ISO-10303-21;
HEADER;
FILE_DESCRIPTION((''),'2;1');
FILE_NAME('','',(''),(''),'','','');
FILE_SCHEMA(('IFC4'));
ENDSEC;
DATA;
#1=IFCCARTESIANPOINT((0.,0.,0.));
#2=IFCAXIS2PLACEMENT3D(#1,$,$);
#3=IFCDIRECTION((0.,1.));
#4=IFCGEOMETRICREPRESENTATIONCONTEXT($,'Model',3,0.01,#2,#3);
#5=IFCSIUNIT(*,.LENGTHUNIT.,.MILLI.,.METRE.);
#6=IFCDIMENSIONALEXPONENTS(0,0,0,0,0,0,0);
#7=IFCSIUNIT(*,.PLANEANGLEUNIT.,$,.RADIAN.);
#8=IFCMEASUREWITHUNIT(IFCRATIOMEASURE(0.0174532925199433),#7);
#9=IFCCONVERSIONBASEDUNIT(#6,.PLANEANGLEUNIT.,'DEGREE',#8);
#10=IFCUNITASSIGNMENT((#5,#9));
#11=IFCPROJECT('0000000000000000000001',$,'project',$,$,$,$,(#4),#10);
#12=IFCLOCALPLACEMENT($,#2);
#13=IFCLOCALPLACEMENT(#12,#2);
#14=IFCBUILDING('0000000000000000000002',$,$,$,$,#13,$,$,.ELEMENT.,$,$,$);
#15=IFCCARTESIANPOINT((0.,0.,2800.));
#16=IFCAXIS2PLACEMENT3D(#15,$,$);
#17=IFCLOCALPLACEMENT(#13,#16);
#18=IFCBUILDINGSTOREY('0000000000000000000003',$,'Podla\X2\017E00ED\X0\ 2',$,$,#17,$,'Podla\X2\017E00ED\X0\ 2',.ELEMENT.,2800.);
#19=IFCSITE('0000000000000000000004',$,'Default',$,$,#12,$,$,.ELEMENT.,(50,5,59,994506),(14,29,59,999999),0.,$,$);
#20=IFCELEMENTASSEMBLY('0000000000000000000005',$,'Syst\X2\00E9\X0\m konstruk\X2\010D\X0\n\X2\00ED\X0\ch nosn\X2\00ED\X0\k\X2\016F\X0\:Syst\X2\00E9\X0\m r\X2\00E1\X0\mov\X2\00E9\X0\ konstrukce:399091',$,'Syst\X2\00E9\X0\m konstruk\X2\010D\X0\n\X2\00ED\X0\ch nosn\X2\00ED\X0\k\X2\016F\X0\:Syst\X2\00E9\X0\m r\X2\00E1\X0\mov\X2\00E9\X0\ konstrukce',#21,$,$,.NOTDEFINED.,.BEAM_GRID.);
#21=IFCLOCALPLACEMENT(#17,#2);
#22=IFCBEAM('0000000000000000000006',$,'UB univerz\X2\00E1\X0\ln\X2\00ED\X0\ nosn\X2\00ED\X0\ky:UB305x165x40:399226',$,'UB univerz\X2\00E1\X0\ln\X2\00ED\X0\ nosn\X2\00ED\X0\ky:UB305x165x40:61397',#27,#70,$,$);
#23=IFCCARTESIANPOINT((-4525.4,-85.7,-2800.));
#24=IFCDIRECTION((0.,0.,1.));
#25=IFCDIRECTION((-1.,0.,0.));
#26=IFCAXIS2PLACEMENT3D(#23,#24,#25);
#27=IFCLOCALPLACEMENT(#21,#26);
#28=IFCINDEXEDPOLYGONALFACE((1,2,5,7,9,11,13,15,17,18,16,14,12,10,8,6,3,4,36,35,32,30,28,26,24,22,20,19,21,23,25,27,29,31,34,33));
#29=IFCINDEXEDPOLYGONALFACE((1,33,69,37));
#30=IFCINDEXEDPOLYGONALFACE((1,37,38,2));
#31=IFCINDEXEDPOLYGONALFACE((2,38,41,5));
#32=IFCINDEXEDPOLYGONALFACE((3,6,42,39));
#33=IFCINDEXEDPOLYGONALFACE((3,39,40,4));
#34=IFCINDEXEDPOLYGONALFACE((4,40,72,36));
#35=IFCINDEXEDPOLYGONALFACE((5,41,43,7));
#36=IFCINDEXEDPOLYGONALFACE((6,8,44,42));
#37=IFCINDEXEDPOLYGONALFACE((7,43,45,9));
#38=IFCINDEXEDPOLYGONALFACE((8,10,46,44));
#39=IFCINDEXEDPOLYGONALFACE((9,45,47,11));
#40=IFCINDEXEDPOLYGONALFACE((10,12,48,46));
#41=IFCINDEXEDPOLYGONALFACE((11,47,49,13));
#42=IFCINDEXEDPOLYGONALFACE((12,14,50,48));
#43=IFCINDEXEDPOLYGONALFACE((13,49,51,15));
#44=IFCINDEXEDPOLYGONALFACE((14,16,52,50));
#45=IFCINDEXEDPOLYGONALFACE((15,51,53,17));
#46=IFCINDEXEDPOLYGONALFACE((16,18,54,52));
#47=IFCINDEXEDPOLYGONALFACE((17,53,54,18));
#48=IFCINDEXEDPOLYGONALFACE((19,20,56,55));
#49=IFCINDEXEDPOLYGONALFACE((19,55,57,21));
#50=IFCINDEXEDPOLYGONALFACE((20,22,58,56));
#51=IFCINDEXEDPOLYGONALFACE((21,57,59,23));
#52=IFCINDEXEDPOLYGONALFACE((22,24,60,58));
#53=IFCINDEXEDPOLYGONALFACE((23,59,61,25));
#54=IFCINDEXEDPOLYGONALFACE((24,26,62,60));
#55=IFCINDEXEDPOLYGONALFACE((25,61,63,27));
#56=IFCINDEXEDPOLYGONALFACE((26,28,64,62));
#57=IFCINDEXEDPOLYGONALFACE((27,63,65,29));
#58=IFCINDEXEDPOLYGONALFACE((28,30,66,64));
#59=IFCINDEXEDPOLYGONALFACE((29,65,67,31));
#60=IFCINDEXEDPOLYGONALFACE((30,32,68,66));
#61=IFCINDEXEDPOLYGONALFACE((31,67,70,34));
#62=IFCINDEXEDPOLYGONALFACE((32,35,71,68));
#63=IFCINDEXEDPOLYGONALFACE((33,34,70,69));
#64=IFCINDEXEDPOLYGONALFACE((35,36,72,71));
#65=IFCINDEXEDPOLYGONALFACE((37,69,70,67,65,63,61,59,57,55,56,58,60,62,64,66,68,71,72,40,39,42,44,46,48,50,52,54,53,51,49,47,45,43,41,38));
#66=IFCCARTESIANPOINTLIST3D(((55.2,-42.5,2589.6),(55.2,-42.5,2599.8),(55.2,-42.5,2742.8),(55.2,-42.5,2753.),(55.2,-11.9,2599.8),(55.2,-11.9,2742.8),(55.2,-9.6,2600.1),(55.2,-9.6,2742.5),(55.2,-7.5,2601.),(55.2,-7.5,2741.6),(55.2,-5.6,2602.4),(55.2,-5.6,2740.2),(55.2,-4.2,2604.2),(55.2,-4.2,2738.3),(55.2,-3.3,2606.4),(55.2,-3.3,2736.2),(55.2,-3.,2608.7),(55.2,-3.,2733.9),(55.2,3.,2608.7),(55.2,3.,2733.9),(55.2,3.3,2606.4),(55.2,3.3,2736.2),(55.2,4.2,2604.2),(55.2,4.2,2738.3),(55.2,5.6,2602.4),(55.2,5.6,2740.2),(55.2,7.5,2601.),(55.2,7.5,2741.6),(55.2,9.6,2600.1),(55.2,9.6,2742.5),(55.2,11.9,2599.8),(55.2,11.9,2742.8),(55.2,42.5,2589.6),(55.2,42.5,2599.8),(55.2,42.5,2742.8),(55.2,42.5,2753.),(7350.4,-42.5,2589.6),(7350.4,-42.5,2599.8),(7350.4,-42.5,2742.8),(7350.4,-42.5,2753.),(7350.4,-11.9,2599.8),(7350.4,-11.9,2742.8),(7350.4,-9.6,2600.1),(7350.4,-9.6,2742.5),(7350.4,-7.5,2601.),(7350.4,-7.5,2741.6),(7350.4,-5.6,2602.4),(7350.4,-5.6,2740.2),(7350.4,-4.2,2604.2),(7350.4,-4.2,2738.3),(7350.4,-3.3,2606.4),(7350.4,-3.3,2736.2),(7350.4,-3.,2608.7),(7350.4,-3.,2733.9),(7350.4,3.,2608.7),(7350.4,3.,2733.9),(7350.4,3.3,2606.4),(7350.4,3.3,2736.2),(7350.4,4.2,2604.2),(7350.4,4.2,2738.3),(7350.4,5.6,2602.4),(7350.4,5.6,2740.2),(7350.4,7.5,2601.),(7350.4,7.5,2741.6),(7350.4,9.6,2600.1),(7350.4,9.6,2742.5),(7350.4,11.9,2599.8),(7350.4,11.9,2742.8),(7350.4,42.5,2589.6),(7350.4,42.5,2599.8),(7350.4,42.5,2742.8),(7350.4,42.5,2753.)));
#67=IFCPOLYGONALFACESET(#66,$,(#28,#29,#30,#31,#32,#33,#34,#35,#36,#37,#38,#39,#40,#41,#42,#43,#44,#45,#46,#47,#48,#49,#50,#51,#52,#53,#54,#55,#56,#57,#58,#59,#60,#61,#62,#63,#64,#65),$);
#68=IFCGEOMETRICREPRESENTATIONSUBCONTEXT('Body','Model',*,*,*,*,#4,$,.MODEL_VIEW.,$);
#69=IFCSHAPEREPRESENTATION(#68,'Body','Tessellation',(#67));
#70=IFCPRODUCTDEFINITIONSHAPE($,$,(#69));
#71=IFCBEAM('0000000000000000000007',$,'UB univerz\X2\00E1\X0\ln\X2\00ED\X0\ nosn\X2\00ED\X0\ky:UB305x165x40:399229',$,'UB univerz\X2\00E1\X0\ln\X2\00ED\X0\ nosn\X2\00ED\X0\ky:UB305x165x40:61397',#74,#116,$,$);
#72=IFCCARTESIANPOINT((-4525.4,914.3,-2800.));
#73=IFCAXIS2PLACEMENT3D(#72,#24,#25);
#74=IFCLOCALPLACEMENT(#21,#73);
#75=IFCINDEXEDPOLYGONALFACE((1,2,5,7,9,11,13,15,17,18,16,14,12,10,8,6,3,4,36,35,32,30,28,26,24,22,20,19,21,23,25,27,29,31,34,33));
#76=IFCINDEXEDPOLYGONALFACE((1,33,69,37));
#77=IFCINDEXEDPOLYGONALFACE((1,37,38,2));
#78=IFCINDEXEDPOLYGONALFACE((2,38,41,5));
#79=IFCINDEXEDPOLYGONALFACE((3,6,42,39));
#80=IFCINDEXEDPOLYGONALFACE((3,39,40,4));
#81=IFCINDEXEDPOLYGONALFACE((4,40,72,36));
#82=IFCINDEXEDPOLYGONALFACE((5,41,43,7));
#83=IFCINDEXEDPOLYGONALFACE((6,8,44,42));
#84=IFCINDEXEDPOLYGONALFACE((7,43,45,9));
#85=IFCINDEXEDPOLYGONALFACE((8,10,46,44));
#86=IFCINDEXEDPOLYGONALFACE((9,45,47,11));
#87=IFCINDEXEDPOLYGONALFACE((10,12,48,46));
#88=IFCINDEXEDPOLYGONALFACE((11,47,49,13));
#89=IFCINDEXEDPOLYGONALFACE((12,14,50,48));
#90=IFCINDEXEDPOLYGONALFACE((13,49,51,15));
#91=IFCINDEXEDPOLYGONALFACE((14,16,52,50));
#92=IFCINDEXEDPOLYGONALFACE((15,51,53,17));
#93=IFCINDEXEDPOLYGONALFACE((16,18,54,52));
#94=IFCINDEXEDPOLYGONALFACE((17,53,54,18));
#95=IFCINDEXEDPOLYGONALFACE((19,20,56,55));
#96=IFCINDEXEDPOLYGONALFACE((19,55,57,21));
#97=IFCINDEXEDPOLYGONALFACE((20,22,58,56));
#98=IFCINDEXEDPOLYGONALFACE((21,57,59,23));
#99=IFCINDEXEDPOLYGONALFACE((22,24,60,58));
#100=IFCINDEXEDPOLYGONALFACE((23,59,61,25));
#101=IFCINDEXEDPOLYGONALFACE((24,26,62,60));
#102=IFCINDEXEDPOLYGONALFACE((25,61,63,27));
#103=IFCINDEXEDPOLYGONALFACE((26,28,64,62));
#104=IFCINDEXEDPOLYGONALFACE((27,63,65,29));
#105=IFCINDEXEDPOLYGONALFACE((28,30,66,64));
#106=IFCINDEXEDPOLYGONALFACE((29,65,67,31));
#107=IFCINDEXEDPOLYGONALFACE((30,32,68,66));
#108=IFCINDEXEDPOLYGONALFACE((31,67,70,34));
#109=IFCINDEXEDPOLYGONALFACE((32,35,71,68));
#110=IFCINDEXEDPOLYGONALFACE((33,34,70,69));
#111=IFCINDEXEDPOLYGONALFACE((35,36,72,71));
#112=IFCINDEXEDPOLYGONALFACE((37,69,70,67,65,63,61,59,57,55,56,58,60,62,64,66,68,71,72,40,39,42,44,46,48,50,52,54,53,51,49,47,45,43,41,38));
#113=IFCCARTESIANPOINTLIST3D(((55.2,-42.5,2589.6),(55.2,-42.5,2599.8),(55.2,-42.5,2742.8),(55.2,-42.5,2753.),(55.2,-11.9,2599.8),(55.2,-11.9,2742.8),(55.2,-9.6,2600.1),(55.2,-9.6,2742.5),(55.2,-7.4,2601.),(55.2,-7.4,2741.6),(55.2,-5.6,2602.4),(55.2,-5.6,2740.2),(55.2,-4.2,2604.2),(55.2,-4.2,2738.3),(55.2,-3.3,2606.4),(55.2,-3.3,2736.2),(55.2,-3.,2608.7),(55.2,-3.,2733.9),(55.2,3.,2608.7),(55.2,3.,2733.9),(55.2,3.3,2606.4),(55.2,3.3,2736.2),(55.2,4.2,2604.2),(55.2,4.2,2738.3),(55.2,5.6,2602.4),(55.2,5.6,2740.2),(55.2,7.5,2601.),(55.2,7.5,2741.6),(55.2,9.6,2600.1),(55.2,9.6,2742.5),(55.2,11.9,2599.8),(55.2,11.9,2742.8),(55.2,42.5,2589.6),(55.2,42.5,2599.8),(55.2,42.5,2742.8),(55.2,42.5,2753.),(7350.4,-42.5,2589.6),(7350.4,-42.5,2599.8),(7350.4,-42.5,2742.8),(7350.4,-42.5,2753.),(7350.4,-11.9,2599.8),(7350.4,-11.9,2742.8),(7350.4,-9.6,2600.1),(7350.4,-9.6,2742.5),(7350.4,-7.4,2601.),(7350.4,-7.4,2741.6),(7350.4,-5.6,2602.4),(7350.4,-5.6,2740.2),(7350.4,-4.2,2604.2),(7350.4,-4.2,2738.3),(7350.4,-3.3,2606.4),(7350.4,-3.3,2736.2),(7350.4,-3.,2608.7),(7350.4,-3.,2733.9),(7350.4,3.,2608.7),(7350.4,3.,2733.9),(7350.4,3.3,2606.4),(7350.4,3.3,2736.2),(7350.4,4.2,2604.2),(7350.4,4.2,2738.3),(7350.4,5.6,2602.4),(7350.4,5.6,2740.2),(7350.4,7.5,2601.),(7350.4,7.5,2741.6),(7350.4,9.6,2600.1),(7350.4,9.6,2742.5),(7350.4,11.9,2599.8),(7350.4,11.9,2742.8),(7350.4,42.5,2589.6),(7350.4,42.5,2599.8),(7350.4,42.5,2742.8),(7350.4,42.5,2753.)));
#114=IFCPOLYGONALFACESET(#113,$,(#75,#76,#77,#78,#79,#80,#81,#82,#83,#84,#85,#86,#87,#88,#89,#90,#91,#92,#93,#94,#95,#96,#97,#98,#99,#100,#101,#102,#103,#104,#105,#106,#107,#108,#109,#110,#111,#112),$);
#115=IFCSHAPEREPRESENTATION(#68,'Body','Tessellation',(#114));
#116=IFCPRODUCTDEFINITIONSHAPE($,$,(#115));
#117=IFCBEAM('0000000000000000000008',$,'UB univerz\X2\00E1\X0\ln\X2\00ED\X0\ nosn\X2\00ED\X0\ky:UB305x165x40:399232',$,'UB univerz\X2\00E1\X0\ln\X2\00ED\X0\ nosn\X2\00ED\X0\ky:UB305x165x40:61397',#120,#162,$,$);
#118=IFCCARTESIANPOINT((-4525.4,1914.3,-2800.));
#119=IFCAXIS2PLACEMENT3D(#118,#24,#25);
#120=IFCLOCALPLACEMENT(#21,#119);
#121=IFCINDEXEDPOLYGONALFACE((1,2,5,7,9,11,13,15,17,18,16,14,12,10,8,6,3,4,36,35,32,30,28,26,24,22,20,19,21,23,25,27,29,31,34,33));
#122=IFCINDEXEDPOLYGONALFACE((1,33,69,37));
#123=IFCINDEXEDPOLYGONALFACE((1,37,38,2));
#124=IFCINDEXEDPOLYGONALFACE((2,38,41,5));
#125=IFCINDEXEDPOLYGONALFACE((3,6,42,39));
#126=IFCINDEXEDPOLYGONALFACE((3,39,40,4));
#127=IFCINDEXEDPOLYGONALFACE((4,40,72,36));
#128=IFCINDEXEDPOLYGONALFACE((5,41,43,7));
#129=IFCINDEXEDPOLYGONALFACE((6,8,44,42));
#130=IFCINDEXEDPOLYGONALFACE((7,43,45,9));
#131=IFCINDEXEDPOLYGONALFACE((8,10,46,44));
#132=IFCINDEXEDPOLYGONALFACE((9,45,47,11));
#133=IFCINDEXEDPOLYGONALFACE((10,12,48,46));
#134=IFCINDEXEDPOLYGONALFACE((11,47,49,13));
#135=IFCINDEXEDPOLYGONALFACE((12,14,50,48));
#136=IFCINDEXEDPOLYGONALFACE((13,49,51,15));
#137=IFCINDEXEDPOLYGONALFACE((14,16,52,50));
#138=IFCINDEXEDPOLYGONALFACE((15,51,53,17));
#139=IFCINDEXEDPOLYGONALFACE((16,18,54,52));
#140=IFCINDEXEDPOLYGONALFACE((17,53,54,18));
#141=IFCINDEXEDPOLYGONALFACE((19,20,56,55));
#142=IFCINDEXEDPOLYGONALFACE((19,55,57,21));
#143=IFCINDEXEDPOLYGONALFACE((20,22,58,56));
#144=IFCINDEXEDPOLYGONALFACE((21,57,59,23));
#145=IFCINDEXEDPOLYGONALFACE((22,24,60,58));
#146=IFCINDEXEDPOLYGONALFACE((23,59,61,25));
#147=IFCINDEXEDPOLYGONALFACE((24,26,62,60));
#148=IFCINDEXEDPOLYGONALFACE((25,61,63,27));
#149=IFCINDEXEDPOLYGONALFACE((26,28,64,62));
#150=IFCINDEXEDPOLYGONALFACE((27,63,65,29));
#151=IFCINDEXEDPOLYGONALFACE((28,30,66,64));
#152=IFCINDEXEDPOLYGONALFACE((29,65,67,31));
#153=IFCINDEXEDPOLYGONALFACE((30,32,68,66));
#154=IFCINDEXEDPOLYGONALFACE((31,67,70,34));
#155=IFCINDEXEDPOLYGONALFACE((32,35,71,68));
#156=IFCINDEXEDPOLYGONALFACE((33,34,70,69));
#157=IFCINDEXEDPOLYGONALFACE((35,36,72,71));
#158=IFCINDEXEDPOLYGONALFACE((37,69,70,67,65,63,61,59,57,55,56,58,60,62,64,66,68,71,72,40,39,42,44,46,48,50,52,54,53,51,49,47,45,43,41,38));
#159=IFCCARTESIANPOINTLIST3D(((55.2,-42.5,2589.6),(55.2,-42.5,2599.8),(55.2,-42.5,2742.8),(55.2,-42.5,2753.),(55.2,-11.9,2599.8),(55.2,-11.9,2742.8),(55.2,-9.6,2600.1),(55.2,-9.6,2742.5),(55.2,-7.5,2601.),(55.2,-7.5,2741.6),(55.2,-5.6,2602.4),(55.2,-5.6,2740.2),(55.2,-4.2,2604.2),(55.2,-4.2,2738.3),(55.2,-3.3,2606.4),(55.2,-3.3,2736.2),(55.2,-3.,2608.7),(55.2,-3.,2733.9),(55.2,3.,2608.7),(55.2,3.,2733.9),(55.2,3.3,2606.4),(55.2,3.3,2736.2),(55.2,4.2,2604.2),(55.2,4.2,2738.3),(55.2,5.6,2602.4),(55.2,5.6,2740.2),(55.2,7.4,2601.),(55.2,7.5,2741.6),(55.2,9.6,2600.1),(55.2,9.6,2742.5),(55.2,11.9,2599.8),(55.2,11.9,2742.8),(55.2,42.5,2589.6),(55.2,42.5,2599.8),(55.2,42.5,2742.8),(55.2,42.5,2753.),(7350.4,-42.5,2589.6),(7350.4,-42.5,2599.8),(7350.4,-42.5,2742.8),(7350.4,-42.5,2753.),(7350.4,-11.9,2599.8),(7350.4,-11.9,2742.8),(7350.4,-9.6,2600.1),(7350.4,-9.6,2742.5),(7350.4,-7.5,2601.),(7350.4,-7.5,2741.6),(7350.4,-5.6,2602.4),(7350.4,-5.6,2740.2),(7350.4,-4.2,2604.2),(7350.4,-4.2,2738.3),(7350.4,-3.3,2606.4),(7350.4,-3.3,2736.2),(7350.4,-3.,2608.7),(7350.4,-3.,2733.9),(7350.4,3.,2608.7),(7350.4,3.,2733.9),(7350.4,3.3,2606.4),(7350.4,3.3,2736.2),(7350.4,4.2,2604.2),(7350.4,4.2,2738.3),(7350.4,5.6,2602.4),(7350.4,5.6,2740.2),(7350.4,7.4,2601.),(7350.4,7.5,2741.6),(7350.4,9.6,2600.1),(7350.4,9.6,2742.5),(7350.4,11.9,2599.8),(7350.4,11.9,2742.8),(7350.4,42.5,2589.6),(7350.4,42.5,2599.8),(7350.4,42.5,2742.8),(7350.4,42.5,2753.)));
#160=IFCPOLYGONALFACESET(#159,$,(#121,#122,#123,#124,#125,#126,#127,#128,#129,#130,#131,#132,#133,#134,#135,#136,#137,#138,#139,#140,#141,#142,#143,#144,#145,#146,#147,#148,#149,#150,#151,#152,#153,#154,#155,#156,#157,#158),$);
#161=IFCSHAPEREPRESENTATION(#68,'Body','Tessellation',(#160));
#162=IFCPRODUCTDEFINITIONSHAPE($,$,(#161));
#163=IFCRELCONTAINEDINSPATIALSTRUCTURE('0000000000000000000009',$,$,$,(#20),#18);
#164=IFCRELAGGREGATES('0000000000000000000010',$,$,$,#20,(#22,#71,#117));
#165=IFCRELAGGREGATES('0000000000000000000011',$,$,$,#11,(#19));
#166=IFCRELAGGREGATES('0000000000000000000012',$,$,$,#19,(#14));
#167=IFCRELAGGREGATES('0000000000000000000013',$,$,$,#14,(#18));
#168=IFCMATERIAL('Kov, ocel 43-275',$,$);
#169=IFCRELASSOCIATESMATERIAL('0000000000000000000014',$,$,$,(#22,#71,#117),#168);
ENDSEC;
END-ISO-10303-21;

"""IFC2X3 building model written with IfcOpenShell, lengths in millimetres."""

from ifc_helpers import new_model, entity, si_unit, converted_unit, direction, frame, frame_2d, origin, place, context, subcontext, project, spatial, i_section, extrude, material, element, aggregate, save


model = new_model("IFC2X3")

# Units and contexts
model_context = context("Model", 3, precision=0.01, world=origin(), true_north=direction((0.0, 1.0)))
body_context = subcontext(model_context, "Body", "Model", "MODEL_VIEW")
ifc_project = project(units=[si_unit("LENGTHUNIT", "METRE", prefix="MILLI"), converted_unit("PLANEANGLEUNIT", "DEGREE", entity("IfcRatioMeasure", 0.0174532925199433), si_unit("PLANEANGLEUNIT", "RADIAN"), dimensions=[0, 0, 0, 0, 0, 0, 0])], contexts=[model_context])

# Site, building, storey
site_placement = place(None, origin())
site = spatial("IfcSite", under=ifc_project, at=site_placement, Name="Default", CompositionType="ELEMENT", RefLatitude=(50, 5, 59, 994506), RefLongitude=(14, 29, 59, 999999), RefElevation=0.0)
building_placement = place(site_placement, origin())
building = spatial("IfcBuilding", under=site, at=building_placement, CompositionType="ELEMENT")
storey_placement = place(building_placement, frame((0.0, 0.0, 2800.0)))
storey = spatial("IfcBuildingStorey", under=building, at=storey_placement, Name="Podlaží 2", LongName="Podlaží 2", CompositionType="ELEMENT", Elevation=2800.0)

# Element assembly, beams
assembly_1_placement = place(storey_placement, origin())
assembly_1 = element("IfcElementAssembly", 1, at=assembly_1_placement, inside=storey, Name="Systém konstrukčních nosníků:Systém rámové konstrukce:399091", ObjectType="Systém konstrukčních nosníků:Systém rámové konstrukce", AssemblyPlace="NOTDEFINED", PredefinedType="BEAM_GRID")
ifc_material = material(Name="Kov, ocel 43-275")
beam_1_placement = place(assembly_1_placement, frame((-4525.4, -85.7, -2800.0), z_axis=(0.0, 0.0, 1.0), x_axis=(-1.0, 0.0, 0.0)))
beam_1 = element("IfcBeam", 2, at=beam_1_placement, material=ifc_material, Name="UB univerzální nosníky:UB305x165x40:399226", ObjectType="UB univerzální nosníky:UB305x165x40:61397", context=body_context, shape_type="SweptSolid", body=[
    extrude(i_section(OverallWidth=85.0, OverallDepth=163.4, WebThickness=6.0, FlangeThickness=10.2, FilletRadius=8.9, at=frame_2d((0.0, 0.0), x_axis=(0.0, 1.0))), frame((55.2, 0.0, 2671.3), z_axis=(1.0, 0.0, 0.0), x_axis=(0.0, 0.0, -1.0)), (0.0, 0.0, 1.0), 7295.2),
])
beam_2_placement = place(assembly_1_placement, frame((-4525.4, 914.3, -2800.0), z_axis=(0.0, 0.0, 1.0), x_axis=(-1.0, 0.0, 0.0)))
beam_2 = element("IfcBeam", 3, at=beam_2_placement, material=ifc_material, Name="UB univerzální nosníky:UB305x165x40:399229", ObjectType="UB univerzální nosníky:UB305x165x40:61397", context=body_context, shape_type="SweptSolid", body=[
    extrude(i_section(OverallWidth=85.0, OverallDepth=163.4, WebThickness=6.0, FlangeThickness=10.2, FilletRadius=8.9, at=frame_2d((0.0, 0.0), x_axis=(0.0, 1.0))), frame((55.2, 0.0, 2671.3), z_axis=(1.0, 0.0, 0.0), x_axis=(0.0, 0.0, -1.0)), (0.0, 0.0, 1.0), 7295.2),
])
beam_3_placement = place(assembly_1_placement, frame((-4525.4, 1914.3, -2800.0), z_axis=(0.0, 0.0, 1.0), x_axis=(-1.0, 0.0, 0.0)))
beam_3 = element("IfcBeam", 4, at=beam_3_placement, material=ifc_material, Name="UB univerzální nosníky:UB305x165x40:399232", ObjectType="UB univerzální nosníky:UB305x165x40:61397", context=body_context, shape_type="SweptSolid", body=[
    extrude(i_section(OverallWidth=85.0, OverallDepth=163.4, WebThickness=6.0, FlangeThickness=10.2, FilletRadius=8.9, at=frame_2d((0.0, 0.0), x_axis=(0.0, 1.0))), frame((55.2, 0.0, 2671.3), z_axis=(1.0, 0.0, 0.0), x_axis=(0.0, 0.0, -1.0)), (0.0, 0.0, 1.0), 7295.2),
])
aggregate(assembly_1, [beam_1, beam_2, beam_3])

save(model, "model.ifc")
